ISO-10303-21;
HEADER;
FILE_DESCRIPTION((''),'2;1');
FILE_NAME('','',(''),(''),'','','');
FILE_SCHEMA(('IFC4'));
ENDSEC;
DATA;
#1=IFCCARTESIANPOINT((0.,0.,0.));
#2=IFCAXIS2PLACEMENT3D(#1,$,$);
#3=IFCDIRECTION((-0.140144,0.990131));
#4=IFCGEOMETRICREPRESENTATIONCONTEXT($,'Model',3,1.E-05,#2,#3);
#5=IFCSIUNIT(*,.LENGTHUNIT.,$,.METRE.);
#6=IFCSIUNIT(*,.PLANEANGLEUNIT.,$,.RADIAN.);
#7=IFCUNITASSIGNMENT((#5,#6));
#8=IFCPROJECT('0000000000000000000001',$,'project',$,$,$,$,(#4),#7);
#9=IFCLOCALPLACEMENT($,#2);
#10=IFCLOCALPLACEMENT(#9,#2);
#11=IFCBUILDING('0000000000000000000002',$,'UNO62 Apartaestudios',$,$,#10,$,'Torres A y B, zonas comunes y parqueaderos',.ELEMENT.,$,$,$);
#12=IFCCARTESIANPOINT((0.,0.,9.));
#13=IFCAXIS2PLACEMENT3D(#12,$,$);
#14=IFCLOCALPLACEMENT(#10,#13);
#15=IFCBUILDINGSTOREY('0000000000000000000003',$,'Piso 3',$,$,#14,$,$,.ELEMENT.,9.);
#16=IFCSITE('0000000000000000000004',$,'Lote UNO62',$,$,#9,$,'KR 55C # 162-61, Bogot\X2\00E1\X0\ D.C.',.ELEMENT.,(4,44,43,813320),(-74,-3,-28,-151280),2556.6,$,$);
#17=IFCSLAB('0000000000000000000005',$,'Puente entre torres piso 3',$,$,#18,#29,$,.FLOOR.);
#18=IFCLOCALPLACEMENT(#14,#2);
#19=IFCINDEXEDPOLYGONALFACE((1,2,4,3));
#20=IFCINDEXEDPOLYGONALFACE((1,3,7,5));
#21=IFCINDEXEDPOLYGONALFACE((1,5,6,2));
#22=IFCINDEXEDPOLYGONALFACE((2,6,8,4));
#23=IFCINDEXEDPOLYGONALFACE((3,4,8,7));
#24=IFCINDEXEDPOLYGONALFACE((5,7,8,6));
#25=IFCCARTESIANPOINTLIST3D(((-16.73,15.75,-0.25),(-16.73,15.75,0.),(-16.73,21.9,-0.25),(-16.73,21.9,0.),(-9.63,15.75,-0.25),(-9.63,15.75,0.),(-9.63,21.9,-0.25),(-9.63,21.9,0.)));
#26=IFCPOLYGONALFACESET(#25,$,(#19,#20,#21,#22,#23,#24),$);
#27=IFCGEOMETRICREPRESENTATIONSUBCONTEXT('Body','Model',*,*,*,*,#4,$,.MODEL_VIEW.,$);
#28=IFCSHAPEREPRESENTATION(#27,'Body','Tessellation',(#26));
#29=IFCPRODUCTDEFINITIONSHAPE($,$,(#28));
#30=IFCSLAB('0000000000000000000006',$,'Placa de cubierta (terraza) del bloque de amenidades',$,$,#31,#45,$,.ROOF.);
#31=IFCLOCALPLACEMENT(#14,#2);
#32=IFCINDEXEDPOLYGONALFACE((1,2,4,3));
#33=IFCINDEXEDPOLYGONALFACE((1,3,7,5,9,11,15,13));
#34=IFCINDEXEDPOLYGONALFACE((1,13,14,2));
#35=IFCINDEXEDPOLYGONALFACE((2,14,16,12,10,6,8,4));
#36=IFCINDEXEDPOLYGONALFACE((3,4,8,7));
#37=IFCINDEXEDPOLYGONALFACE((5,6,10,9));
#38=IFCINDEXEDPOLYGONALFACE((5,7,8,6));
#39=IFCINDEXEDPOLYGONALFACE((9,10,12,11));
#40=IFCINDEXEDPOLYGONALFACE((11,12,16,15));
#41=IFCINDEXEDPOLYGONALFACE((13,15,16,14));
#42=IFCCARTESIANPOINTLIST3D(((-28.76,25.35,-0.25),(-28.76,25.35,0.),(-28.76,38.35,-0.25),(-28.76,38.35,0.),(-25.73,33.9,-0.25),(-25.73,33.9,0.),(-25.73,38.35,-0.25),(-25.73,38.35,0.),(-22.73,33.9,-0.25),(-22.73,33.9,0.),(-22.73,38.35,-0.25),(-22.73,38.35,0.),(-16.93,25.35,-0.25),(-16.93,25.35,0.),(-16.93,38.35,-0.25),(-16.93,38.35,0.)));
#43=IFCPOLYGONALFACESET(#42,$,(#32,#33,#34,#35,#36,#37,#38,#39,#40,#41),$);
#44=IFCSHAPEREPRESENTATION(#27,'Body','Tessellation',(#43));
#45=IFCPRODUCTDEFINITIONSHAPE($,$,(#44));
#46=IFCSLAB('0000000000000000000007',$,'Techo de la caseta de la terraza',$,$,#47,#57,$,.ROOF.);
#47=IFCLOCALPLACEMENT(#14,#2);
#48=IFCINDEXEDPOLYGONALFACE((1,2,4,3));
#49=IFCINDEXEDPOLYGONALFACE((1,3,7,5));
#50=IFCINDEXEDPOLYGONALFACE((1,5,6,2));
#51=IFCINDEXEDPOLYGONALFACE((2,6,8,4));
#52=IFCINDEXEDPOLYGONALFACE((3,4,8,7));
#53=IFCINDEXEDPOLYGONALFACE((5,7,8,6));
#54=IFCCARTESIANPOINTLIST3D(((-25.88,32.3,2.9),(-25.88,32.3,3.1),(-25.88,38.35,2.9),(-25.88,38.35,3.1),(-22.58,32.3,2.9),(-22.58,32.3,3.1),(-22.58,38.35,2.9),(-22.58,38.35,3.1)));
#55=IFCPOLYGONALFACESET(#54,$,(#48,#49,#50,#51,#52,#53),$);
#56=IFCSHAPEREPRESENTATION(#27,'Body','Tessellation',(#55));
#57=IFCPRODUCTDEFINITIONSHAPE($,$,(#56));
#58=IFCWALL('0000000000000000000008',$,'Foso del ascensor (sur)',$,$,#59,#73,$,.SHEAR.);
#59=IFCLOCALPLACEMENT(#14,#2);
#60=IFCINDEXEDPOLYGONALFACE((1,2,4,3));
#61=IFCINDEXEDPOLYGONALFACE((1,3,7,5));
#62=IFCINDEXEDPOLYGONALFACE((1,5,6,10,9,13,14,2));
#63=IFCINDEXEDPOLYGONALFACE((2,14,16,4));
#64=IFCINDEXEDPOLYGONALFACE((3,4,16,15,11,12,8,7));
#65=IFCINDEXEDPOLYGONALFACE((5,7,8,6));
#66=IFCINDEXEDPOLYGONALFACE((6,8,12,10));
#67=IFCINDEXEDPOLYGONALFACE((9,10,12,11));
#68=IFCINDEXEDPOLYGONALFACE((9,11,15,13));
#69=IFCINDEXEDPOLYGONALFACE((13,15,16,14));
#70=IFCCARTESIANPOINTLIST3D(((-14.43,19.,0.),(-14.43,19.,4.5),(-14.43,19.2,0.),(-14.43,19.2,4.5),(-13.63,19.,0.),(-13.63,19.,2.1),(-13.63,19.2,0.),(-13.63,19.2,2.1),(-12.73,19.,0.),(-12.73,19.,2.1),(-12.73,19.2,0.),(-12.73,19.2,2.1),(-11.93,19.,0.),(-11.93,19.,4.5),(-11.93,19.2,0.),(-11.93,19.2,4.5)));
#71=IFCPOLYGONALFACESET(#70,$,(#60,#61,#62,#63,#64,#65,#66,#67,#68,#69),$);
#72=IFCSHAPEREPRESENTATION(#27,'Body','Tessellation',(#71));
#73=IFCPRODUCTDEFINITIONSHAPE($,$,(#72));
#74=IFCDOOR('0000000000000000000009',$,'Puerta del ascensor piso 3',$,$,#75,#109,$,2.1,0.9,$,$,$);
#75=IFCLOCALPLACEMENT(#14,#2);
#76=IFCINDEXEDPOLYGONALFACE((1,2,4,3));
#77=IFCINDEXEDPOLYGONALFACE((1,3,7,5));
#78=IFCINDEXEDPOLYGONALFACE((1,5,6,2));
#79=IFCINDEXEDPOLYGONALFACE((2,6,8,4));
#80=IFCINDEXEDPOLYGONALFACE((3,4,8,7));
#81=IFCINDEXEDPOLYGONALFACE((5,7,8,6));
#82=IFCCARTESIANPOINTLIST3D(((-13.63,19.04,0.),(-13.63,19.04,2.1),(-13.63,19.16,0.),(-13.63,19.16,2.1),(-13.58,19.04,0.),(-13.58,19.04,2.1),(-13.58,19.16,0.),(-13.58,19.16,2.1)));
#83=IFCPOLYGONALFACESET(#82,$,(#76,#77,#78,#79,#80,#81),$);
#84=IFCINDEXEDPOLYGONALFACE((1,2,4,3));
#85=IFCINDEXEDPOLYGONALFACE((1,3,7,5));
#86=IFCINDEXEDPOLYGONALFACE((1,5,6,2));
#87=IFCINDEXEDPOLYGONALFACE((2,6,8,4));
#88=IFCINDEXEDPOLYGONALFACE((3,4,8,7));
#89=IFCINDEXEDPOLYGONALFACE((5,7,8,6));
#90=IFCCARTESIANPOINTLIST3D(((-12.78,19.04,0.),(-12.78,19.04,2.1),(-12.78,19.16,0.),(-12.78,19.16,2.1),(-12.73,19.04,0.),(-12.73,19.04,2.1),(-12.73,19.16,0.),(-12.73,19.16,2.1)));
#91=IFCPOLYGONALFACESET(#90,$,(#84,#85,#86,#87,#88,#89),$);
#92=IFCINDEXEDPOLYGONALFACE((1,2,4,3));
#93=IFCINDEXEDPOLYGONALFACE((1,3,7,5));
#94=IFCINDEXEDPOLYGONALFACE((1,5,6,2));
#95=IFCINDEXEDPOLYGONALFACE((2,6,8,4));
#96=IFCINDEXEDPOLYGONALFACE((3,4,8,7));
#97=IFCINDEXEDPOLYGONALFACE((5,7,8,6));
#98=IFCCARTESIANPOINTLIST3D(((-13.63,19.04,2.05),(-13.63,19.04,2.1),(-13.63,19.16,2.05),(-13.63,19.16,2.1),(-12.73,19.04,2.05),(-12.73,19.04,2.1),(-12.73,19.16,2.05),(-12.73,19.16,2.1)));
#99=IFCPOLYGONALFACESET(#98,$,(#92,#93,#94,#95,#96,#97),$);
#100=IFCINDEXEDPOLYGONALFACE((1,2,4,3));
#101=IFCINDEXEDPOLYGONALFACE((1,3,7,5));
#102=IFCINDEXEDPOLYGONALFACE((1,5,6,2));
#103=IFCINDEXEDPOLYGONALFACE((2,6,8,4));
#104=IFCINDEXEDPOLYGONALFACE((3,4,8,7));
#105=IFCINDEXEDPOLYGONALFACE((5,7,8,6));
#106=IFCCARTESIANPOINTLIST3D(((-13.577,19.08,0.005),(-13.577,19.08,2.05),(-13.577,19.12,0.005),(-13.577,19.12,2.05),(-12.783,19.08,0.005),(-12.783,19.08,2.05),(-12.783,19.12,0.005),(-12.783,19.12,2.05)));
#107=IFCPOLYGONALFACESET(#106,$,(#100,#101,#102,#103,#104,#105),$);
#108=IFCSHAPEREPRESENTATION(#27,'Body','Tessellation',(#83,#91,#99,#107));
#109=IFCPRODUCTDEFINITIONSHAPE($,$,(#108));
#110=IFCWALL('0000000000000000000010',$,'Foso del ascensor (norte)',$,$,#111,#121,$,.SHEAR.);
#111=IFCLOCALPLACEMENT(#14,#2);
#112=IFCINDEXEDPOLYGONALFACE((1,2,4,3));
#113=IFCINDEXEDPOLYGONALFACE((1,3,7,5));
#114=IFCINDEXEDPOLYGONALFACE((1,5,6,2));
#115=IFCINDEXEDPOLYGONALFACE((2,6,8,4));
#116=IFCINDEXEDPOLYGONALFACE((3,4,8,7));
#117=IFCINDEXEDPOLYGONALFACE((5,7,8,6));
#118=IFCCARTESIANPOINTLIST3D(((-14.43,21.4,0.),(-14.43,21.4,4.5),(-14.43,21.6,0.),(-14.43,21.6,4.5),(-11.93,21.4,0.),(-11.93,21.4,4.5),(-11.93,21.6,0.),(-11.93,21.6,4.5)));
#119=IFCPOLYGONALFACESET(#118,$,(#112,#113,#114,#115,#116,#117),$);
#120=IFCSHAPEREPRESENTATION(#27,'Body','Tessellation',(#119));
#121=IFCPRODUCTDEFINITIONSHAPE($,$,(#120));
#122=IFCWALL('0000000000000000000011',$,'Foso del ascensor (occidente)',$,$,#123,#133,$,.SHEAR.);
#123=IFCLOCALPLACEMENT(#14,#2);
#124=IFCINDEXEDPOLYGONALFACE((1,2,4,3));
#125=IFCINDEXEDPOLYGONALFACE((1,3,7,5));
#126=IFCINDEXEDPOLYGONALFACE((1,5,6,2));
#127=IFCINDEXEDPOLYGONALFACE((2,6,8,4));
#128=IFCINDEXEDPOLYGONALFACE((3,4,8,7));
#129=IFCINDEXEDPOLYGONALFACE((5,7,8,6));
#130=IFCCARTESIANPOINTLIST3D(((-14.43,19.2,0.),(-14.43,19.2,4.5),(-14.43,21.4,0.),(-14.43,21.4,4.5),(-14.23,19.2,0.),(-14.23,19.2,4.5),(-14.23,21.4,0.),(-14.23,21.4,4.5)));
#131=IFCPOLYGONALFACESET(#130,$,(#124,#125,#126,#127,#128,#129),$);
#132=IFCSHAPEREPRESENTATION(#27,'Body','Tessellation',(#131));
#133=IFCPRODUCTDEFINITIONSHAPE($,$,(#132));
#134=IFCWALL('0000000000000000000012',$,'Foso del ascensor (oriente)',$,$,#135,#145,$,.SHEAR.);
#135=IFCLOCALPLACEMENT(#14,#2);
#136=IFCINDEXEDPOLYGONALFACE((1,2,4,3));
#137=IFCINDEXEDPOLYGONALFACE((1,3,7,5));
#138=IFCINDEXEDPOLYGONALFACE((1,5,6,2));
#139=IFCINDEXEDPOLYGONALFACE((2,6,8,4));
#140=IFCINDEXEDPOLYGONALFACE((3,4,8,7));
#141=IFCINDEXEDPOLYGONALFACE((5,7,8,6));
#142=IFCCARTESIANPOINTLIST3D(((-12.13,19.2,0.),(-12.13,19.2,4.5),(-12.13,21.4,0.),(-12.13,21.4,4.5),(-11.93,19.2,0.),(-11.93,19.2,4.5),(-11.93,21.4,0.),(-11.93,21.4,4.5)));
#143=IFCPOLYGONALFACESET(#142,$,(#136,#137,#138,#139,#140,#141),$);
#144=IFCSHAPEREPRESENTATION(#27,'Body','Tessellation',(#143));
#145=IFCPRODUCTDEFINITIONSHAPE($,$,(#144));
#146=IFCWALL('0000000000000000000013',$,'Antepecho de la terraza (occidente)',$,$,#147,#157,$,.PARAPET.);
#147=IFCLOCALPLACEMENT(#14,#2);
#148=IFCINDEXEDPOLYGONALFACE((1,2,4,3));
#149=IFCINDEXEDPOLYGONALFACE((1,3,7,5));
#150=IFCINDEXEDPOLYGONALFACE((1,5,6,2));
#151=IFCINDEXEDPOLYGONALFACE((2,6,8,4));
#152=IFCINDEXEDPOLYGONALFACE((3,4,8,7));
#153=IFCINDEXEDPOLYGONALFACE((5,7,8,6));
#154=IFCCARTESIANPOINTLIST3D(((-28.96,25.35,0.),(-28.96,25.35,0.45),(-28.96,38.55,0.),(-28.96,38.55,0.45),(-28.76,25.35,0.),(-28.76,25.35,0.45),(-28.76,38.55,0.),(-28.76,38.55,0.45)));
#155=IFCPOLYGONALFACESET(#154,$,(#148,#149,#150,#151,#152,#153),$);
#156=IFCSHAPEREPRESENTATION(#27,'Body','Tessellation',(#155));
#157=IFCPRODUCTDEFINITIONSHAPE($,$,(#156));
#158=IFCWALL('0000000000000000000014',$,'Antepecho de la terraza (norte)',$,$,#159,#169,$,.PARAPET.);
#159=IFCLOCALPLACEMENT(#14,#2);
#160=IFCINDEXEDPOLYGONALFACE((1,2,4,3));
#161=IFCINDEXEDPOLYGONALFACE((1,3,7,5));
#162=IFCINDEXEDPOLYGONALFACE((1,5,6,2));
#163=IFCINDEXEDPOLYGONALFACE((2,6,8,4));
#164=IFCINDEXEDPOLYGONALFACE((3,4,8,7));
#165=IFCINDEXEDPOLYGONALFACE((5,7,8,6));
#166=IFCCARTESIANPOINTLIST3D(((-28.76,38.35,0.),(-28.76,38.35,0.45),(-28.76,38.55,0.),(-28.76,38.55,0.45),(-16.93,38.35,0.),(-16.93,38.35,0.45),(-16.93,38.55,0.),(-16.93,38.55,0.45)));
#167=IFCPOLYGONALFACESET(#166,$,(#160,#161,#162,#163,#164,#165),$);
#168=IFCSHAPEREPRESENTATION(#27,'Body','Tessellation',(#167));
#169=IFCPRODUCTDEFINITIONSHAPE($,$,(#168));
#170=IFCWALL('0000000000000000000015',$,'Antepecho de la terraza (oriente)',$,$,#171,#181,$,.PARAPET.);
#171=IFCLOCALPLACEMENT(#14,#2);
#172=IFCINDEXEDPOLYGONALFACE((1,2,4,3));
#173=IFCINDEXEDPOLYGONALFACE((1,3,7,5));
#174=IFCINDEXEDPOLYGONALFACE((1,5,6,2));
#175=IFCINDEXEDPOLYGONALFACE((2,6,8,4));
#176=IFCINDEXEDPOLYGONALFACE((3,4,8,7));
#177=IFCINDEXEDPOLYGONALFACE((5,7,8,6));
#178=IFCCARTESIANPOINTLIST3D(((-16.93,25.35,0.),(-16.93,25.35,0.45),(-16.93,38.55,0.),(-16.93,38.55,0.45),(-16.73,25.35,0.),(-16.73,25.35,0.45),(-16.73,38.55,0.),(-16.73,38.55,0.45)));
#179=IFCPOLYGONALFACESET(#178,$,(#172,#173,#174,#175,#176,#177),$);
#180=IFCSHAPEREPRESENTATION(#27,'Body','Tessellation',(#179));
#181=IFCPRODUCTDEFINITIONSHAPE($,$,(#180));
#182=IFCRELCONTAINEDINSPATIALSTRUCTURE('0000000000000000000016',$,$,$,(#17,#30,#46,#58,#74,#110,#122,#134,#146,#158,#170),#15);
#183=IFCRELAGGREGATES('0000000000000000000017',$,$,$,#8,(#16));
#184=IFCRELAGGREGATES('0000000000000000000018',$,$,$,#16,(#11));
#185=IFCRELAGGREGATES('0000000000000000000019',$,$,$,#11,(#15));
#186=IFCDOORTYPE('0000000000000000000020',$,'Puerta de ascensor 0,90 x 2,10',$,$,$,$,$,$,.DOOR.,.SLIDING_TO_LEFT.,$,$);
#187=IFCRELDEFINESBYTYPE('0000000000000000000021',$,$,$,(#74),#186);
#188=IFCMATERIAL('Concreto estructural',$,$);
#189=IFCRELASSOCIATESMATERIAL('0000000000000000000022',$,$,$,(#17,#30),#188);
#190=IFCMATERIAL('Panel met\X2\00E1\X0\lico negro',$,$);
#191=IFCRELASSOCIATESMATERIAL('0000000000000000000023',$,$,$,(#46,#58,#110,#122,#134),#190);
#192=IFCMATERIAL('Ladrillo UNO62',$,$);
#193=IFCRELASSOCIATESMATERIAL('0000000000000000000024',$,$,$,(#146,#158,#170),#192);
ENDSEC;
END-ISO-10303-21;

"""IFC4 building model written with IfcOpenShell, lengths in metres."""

from ifc_helpers import new_model, si_unit, direction, frame, frame_2d, origin, place, context, subcontext, project, spatial, rectangle, extrude, source, transform, mapped, material, type_object, type_shapes, element, fill, save


model = new_model("IFC4")

# Units and contexts
model_context = context("Model", 3, precision=1e-05, world=origin(), true_north=direction((-0.140144, 0.990131)))
body_context = subcontext(model_context, "Body", "Model", "MODEL_VIEW")
ifc_project = project(units=[si_unit("LENGTHUNIT", "METRE"), si_unit("PLANEANGLEUNIT", "RADIAN")], contexts=[model_context])

# Site, building, storey
site_placement = place(None, origin())
site = spatial("IfcSite", under=ifc_project, at=site_placement, Name="Lote UNO62", LongName="KR 55C # 162-61, Bogotá D.C.", CompositionType="ELEMENT", RefLatitude=(4, 44, 43, 813320), RefLongitude=(-74, -3, -28, -151280), RefElevation=2556.6)
building_placement = place(site_placement, origin())
building = spatial("IfcBuilding", under=site, at=building_placement, Name="UNO62 Apartaestudios", LongName="Torres A y B, zonas comunes y parqueaderos", CompositionType="ELEMENT")
storey_placement = place(building_placement, frame((0.0, 0.0, 9.0)))
storey = spatial("IfcBuildingStorey", under=building, at=storey_placement, Name="Piso 3", CompositionType="ELEMENT", Elevation=9.0)

# Shared definitions
ifc_material_1 = material(Name="Ladrillo UNO62")

# Shared definitions
ifc_material_2 = material(Name="Panel metálico negro")

# Slab
ifc_material_3 = material(Name="Concreto estructural")
slab_1_placement = place(storey_placement, origin())
element("IfcSlab", 1, at=slab_1_placement, inside=storey, material=ifc_material_3, Name="Puente entre torres piso 3", PredefinedType="FLOOR", context=body_context, shape_type="SweptSolid", body=[
    extrude(rectangle(XDim=7.1, YDim=6.15, at=frame_2d((-13.18, 18.825))), frame((0.0, 0.0, -0.25)), (0.0, 0.0, 1.0), 0.25),
])

# Slab, opening
slab_2_placement = place(storey_placement, origin())
slab_2 = element("IfcSlab", 2, at=slab_2_placement, inside=storey, material=ifc_material_3, Name="Placa de cubierta (terraza) del bloque de amenidades", PredefinedType="ROOF", context=body_context, shape_type="SweptSolid", body=[
    extrude(rectangle(XDim=11.83, YDim=13.0, at=frame_2d((-22.845, 31.85))), frame((0.0, 0.0, -0.25)), (0.0, 0.0, 1.0), 0.25),
])
opening_1_placement = place(slab_2_placement, origin())
element("IfcOpeningElement", 3, at=opening_1_placement, cuts=slab_2, PredefinedType="OPENING", context=body_context, shape_type="SweptSolid", body=[
    extrude(rectangle(XDim=3.0, YDim=4.45, at=frame_2d((-24.23, 36.125))), frame((0.0, 0.0, -0.3)), (0.0, 0.0, 1.0), 0.35),
])

# Slab
slab_3_placement = place(storey_placement, origin())
element("IfcSlab", 4, at=slab_3_placement, inside=storey, material=ifc_material_2, Name="Techo de la caseta de la terraza", PredefinedType="ROOF", context=body_context, shape_type="SweptSolid", body=[
    extrude(rectangle(XDim=3.3, YDim=6.05, at=frame_2d((-24.23, 35.325))), frame((0.0, 0.0, 2.9)), (0.0, 0.0, 1.0), 0.2),
])

# Wall, opening, door
wall_1_placement = place(storey_placement, origin())
wall_1 = element("IfcWall", 5, at=wall_1_placement, inside=storey, material=ifc_material_2, Name="Foso del ascensor (sur)", PredefinedType="SHEAR", context=body_context, shape_type="SweptSolid", body=[
    extrude(rectangle(XDim=2.5, YDim=0.2, at=frame_2d((-13.18, 19.1))), origin(), (0.0, 0.0, 1.0), 4.5),
])
opening_2_placement = place(wall_1_placement, origin())
opening_2 = element("IfcOpeningElement", 6, at=opening_2_placement, cuts=wall_1, PredefinedType="OPENING", context=body_context, shape_type="SweptSolid", body=[
    extrude(rectangle(XDim=0.9, YDim=0.3, at=frame_2d((-13.18, 19.1))), origin(), (0.0, 0.0, 1.0), 2.1),
])
door_type_1 = type_object("IfcDoorType", Name="Puerta de ascensor 0,90 x 2,10", OperationType="SLIDING_TO_LEFT", PredefinedType="DOOR")
shared_shape_1 = source(origin(), body_context, "Body", "SweptSolid", [
    extrude(rectangle(XDim=0.05, YDim=0.12, at=frame_2d((0.025, 0.0))), origin(), (0.0, 0.0, 1.0), 2.1),
    extrude(rectangle(XDim=0.05, YDim=0.12, at=frame_2d((0.875, 0.0))), origin(), (0.0, 0.0, 1.0), 2.1),
    extrude(rectangle(XDim=0.9, YDim=0.12, at=frame_2d((0.45, 0.0))), frame((0.0, 0.0, 2.05)), (0.0, 0.0, 1.0), 0.05),
    extrude(rectangle(XDim=0.794, YDim=0.04, at=frame_2d((0.45, 0.0))), frame((0.0, 0.0, 0.005)), (0.0, 0.0, 1.0), 2.045),
])
type_shapes(door_type_1, [shared_shape_1])
door_1_placement = place(storey_placement, frame((-13.63, 19.1, 0.0), z_axis=(0.0, 0.0, 1.0), x_axis=(1.0, 0.0, 0.0)))
door_1 = element("IfcDoor", 7, at=door_1_placement, inside=storey, type_object=door_type_1, Name="Puerta del ascensor piso 3", OverallHeight=2.1, OverallWidth=0.9, context=body_context, shape_type="MappedRepresentation", body=[
    mapped(shared_shape_1, transform((0.0, 0.0, 0.0))),
])
fill(opening_2, door_1)

# Walls
wall_2_placement = place(storey_placement, origin())
element("IfcWall", 8, at=wall_2_placement, inside=storey, material=ifc_material_2, Name="Foso del ascensor (norte)", PredefinedType="SHEAR", context=body_context, shape_type="SweptSolid", body=[
    extrude(rectangle(XDim=2.5, YDim=0.2, at=frame_2d((-13.18, 21.5))), origin(), (0.0, 0.0, 1.0), 4.5),
])
wall_3_placement = place(storey_placement, origin())
element("IfcWall", 9, at=wall_3_placement, inside=storey, material=ifc_material_2, Name="Foso del ascensor (occidente)", PredefinedType="SHEAR", context=body_context, shape_type="SweptSolid", body=[
    extrude(rectangle(XDim=0.2, YDim=2.2, at=frame_2d((-14.33, 20.3))), origin(), (0.0, 0.0, 1.0), 4.5),
])
wall_4_placement = place(storey_placement, origin())
element("IfcWall", 10, at=wall_4_placement, inside=storey, material=ifc_material_2, Name="Foso del ascensor (oriente)", PredefinedType="SHEAR", context=body_context, shape_type="SweptSolid", body=[
    extrude(rectangle(XDim=0.2, YDim=2.2, at=frame_2d((-12.03, 20.3))), origin(), (0.0, 0.0, 1.0), 4.5),
])
wall_5_placement = place(storey_placement, origin())
element("IfcWall", 11, at=wall_5_placement, inside=storey, material=ifc_material_1, Name="Antepecho de la terraza (occidente)", PredefinedType="PARAPET", context=body_context, shape_type="SweptSolid", body=[
    extrude(rectangle(XDim=0.2, YDim=13.2, at=frame_2d((-28.86, 31.95))), origin(), (0.0, 0.0, 1.0), 0.45),
])
wall_6_placement = place(storey_placement, origin())
element("IfcWall", 12, at=wall_6_placement, inside=storey, material=ifc_material_1, Name="Antepecho de la terraza (norte)", PredefinedType="PARAPET", context=body_context, shape_type="SweptSolid", body=[
    extrude(rectangle(XDim=11.83, YDim=0.2, at=frame_2d((-22.845, 38.45))), origin(), (0.0, 0.0, 1.0), 0.45),
])
wall_7_placement = place(storey_placement, origin())
element("IfcWall", 13, at=wall_7_placement, inside=storey, material=ifc_material_1, Name="Antepecho de la terraza (oriente)", PredefinedType="PARAPET", context=body_context, shape_type="SweptSolid", body=[
    extrude(rectangle(XDim=0.2, YDim=13.2, at=frame_2d((-16.83, 31.95))), origin(), (0.0, 0.0, 1.0), 0.45),
])

save(model, "model.ifc")
